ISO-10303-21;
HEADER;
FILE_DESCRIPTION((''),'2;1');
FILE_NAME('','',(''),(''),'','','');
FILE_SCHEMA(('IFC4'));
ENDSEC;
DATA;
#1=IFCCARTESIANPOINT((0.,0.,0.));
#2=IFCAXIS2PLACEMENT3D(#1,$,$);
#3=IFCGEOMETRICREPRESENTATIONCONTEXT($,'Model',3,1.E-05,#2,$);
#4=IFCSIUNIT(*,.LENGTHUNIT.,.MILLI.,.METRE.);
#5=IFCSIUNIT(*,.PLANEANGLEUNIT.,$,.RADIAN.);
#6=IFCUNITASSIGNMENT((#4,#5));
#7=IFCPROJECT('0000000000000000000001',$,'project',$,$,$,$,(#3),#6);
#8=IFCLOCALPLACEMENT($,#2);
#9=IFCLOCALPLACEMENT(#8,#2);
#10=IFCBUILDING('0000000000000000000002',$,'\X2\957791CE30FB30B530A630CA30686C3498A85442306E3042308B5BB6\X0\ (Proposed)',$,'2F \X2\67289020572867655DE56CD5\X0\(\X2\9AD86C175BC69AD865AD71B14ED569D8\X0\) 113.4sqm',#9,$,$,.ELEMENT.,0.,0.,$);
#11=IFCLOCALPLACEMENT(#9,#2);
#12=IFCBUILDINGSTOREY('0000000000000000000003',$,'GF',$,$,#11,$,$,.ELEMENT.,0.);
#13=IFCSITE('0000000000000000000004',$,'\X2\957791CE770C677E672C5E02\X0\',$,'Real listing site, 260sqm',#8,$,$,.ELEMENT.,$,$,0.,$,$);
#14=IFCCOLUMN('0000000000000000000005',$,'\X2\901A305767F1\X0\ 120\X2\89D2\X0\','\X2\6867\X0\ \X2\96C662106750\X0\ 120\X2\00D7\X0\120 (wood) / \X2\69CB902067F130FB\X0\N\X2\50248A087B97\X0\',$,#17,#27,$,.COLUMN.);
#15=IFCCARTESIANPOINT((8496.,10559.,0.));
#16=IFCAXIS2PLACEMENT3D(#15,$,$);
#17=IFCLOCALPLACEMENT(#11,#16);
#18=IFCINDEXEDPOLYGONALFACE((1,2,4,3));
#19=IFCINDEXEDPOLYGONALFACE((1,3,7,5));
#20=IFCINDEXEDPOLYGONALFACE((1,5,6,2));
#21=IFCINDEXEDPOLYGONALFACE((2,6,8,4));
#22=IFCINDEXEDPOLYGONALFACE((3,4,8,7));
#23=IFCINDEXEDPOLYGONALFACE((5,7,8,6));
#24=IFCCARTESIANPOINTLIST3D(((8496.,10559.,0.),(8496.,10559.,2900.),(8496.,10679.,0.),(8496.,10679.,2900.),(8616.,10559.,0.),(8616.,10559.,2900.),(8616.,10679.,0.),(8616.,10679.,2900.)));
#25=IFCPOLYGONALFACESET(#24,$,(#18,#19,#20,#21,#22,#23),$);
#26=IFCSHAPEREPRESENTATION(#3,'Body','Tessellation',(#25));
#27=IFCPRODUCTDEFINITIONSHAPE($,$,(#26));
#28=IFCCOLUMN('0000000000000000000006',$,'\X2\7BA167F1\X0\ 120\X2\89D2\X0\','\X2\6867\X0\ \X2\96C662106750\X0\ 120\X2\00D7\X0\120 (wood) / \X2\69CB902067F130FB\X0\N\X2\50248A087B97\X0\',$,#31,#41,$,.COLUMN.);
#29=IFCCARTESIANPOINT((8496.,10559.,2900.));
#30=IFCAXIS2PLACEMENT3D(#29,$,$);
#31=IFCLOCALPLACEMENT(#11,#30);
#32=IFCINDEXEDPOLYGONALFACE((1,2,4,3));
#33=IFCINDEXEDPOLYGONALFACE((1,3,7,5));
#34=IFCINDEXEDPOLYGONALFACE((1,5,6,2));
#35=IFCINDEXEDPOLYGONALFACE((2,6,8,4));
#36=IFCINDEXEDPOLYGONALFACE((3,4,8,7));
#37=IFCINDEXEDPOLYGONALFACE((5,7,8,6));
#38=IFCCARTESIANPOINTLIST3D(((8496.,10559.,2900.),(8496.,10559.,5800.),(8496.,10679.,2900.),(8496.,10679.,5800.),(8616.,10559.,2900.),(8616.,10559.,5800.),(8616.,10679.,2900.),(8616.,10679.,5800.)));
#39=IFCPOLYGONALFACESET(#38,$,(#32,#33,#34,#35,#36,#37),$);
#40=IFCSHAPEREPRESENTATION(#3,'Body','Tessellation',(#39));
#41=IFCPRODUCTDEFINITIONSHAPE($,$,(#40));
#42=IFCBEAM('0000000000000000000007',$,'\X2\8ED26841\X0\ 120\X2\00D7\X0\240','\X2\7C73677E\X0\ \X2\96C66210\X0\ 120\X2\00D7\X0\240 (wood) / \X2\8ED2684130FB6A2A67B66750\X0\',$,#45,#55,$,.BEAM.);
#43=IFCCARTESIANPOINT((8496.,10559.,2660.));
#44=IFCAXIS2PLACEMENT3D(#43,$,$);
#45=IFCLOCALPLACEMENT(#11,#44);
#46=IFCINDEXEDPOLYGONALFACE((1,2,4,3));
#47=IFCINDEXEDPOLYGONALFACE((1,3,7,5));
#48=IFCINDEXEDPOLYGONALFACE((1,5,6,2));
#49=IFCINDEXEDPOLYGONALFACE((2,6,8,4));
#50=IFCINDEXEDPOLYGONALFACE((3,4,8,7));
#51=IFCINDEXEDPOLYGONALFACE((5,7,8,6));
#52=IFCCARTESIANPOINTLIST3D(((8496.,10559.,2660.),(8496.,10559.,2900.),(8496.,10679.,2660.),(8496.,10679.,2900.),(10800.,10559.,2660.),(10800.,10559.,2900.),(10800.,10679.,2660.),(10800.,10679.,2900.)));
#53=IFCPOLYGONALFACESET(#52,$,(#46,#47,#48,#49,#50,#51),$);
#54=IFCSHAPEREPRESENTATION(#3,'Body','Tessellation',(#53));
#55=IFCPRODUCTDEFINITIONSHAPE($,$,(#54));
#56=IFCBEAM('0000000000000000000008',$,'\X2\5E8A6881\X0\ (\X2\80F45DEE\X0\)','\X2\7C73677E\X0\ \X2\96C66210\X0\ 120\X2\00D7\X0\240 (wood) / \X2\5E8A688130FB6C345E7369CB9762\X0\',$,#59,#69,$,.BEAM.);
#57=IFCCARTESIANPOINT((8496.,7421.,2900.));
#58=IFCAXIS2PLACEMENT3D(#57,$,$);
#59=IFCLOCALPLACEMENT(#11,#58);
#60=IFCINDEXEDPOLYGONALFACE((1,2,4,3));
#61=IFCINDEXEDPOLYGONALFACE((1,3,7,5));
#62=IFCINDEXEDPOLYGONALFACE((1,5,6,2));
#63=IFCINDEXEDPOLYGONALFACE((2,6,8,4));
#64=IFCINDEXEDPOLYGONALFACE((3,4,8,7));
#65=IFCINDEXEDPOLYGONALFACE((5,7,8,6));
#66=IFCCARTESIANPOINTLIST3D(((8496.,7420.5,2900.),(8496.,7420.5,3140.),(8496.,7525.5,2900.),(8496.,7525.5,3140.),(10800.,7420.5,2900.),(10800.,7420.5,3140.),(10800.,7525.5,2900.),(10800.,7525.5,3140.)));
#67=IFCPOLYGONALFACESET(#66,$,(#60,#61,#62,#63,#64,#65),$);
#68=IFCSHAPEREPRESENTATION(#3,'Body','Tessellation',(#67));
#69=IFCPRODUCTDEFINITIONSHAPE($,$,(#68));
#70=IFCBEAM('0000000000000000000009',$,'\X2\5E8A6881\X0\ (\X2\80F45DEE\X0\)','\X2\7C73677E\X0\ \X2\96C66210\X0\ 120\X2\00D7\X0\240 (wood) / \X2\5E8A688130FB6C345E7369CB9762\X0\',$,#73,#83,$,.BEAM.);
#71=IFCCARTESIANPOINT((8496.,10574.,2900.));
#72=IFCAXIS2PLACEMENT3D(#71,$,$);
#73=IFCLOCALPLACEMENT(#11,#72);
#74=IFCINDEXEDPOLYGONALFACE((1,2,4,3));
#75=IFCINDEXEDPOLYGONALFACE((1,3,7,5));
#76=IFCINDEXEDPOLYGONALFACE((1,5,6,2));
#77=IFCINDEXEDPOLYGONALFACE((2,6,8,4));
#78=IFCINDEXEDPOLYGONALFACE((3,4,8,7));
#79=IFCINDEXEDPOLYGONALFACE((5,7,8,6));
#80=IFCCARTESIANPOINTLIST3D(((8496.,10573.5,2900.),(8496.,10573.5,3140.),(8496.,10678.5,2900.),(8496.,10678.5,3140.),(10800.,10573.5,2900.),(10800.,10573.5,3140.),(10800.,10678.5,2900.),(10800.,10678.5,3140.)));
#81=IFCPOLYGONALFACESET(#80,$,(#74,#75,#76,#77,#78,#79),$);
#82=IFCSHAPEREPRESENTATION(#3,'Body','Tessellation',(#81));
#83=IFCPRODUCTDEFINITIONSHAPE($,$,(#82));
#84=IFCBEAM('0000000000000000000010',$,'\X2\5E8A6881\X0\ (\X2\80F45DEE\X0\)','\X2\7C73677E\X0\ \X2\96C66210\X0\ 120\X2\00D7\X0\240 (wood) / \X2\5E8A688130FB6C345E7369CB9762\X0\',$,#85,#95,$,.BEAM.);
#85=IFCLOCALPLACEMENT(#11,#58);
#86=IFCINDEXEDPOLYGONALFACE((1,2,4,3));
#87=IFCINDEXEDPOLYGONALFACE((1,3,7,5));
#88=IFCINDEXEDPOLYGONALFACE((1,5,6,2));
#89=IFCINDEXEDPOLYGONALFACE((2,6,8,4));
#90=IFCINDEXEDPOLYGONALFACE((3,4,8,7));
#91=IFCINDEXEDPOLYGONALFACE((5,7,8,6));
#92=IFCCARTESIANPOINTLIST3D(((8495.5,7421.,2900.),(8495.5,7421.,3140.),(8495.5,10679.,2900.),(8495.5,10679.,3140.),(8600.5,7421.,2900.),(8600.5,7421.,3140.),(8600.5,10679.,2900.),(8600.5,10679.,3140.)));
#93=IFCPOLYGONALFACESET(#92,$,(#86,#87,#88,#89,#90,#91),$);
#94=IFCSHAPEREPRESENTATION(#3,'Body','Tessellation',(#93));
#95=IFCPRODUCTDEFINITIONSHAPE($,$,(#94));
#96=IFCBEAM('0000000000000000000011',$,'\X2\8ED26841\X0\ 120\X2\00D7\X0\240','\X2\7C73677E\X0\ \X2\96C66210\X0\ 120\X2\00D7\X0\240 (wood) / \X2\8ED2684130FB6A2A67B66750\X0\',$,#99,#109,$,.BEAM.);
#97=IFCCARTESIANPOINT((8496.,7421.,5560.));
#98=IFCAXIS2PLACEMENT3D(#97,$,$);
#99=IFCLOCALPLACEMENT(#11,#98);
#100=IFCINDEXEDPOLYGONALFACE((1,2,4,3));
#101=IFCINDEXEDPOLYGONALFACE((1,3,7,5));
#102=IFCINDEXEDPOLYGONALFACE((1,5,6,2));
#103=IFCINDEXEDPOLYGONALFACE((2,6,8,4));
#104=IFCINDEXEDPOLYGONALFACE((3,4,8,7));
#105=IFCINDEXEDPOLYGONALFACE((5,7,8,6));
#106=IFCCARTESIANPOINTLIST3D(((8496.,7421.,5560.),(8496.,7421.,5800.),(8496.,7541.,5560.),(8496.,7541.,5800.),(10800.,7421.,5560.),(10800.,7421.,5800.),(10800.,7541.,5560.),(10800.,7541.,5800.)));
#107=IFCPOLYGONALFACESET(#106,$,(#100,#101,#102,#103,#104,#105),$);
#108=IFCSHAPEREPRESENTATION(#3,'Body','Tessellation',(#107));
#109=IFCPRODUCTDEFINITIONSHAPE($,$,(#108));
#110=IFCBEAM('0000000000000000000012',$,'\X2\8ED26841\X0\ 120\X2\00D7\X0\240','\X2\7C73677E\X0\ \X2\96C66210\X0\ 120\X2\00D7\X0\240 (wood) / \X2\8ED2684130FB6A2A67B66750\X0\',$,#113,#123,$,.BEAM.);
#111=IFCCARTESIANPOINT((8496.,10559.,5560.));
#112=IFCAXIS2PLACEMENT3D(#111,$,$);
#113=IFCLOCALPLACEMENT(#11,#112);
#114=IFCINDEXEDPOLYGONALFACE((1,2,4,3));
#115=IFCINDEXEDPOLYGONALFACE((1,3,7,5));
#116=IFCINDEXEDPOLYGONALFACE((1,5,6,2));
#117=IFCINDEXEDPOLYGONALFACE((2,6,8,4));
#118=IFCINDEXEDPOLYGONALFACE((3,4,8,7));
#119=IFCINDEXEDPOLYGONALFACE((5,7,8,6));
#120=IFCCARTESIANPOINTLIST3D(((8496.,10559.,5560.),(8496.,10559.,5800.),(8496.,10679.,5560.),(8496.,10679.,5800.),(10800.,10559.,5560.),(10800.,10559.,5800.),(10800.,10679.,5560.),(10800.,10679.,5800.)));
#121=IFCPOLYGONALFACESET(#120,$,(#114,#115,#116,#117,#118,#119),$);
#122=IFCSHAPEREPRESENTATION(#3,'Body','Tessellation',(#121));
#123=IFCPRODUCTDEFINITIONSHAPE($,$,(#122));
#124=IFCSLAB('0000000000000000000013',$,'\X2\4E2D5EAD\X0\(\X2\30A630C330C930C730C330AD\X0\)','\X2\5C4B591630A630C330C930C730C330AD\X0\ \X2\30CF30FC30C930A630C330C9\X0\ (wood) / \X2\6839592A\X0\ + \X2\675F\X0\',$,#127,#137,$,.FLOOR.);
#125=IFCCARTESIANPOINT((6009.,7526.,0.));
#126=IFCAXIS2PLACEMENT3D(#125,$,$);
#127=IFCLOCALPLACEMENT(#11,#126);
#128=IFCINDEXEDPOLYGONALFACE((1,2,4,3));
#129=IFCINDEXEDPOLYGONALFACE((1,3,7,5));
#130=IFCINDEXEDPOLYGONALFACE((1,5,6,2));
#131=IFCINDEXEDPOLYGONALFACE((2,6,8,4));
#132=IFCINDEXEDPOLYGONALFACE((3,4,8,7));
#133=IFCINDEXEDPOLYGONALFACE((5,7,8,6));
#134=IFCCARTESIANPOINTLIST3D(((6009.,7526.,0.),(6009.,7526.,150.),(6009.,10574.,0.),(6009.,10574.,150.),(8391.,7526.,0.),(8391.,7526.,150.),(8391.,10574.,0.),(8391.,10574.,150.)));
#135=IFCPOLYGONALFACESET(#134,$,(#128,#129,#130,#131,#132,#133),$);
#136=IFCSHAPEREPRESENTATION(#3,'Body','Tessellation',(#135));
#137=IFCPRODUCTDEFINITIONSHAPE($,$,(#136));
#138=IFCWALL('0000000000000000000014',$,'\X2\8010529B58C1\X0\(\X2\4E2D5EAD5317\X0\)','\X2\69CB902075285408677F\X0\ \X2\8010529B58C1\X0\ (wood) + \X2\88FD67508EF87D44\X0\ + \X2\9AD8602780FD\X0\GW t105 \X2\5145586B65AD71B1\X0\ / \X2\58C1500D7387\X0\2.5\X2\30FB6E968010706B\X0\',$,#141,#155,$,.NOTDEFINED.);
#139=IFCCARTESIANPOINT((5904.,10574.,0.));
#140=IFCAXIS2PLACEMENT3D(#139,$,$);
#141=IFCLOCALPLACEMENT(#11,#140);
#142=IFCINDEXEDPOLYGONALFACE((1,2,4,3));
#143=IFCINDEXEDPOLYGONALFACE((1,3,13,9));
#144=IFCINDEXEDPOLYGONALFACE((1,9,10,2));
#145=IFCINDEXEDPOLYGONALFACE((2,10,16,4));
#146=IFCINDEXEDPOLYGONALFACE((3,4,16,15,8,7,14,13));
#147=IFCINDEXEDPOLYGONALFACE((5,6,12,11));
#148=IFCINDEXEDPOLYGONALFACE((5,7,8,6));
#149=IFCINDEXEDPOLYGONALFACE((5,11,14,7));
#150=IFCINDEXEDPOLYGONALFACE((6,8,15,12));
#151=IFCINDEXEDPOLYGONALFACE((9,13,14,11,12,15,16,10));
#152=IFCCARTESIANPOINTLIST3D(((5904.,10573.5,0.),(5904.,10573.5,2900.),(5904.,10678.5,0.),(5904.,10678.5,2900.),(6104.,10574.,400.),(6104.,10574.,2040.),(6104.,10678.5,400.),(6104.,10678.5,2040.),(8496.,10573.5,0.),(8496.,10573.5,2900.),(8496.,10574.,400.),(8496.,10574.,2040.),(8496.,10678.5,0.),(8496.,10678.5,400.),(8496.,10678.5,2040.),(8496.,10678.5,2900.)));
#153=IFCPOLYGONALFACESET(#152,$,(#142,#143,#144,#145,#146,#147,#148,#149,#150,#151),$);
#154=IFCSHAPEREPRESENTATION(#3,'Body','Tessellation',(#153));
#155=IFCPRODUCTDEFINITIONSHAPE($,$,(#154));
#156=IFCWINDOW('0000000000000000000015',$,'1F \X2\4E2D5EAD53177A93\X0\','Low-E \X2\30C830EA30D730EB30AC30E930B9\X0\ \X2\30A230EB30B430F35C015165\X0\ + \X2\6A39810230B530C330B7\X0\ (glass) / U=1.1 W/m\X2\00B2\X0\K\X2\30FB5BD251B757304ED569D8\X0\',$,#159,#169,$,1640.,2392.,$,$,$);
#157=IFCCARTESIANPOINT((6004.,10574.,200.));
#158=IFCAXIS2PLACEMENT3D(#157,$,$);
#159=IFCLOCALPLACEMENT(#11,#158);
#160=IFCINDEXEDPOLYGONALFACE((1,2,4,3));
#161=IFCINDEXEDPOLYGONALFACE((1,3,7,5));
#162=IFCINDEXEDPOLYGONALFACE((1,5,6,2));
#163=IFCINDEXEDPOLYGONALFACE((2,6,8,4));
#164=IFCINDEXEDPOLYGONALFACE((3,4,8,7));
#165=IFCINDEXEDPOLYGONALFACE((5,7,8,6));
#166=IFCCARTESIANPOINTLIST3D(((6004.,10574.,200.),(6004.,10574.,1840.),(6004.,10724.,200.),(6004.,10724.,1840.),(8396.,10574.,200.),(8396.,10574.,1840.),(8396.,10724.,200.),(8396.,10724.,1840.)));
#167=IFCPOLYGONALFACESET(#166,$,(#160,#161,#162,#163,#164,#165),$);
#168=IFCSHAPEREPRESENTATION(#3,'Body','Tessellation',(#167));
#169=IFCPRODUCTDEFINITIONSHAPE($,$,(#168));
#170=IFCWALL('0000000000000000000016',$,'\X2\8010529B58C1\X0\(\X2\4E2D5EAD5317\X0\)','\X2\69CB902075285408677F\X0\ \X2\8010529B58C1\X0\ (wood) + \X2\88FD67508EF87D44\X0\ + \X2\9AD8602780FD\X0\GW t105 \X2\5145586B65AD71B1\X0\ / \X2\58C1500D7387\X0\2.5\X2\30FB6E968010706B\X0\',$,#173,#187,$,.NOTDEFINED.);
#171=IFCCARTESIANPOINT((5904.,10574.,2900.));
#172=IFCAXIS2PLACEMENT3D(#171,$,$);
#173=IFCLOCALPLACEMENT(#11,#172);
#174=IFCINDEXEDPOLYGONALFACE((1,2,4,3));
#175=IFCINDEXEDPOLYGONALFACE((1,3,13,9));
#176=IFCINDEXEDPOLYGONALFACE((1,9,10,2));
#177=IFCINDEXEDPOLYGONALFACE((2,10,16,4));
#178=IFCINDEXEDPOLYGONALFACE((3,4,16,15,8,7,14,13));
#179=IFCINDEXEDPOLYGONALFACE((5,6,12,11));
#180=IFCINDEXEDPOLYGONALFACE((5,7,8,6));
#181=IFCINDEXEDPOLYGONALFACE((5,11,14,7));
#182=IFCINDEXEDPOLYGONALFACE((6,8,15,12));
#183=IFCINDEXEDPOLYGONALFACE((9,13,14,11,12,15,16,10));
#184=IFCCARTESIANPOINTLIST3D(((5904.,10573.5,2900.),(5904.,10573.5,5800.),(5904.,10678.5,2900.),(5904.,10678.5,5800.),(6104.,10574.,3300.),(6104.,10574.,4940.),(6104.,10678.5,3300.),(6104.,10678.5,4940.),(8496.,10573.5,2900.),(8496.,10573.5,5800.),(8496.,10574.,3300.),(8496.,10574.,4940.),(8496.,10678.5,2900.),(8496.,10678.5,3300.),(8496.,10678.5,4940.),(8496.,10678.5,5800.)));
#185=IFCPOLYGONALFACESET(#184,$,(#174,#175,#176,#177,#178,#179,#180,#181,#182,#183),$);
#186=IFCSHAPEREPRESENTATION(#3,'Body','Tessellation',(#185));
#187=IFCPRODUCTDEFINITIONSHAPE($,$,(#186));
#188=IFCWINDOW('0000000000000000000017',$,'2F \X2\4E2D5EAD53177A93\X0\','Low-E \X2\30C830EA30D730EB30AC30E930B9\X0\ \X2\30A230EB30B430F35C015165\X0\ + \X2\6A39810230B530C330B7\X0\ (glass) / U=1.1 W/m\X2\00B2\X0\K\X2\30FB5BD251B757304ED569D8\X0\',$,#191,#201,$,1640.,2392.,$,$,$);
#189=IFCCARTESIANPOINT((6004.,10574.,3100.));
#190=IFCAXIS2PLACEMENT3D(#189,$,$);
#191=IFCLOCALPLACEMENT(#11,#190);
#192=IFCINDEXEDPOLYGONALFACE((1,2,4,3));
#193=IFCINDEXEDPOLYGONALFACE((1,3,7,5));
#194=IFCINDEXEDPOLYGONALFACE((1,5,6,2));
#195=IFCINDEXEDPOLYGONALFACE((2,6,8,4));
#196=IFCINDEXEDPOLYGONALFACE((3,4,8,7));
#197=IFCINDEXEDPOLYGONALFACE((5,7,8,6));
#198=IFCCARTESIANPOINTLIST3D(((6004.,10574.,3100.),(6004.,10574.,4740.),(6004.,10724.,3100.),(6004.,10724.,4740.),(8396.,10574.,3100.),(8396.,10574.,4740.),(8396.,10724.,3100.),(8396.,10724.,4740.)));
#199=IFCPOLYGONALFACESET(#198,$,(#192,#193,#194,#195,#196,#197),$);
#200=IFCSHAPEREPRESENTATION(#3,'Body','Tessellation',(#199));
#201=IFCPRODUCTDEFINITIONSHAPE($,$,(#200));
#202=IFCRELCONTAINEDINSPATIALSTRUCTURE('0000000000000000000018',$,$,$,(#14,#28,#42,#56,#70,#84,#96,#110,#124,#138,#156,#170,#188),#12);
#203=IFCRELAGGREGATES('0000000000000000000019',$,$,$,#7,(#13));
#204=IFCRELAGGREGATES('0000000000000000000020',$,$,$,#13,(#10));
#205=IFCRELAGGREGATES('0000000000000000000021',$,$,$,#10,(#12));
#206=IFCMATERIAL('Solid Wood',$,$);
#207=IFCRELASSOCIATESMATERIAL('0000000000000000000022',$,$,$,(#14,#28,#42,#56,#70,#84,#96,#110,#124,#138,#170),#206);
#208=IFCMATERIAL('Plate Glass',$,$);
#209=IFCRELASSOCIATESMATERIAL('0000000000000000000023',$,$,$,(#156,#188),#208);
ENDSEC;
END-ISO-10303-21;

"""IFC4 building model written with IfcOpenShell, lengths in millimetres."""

from ifc_helpers import new_model, si_unit, frame, frame_2d, origin, place, context, project, spatial, rectangle, extrude, material, element, fill, save


model = new_model("IFC4")

# Units and contexts
model_context = context("Model", 3, precision=1e-05, world=origin())
ifc_project = project(units=[si_unit("LENGTHUNIT", "METRE", prefix="MILLI"), si_unit("PLANEANGLEUNIT", "RADIAN")], contexts=[model_context])

# Site, building, storey
site_placement = place(None, origin())
site = spatial("IfcSite", under=ifc_project, at=site_placement, Name="長野県松本市", ObjectType="Real listing site, 260sqm", CompositionType="ELEMENT", RefElevation=0.0)
building_placement = place(site_placement, origin())
building = spatial("IfcBuilding", under=site, at=building_placement, Name="長野・サウナと水風呂のある家 (Proposed)", ObjectType="2F 木造在来工法(高気密高断熱仕様) 113.4sqm", CompositionType="ELEMENT", ElevationOfRefHeight=0.0, ElevationOfTerrain=0.0)
storey_placement = place(building_placement, origin())
storey = spatial("IfcBuildingStorey", under=building, at=storey_placement, Name="GF", CompositionType="ELEMENT", Elevation=0.0)

# Columns
ifc_material_1 = material(Name="Solid Wood")
column_1_placement = place(storey_placement, frame((8496.0, 10559.0, 0.0)))
element("IfcColumn", 1, at=column_1_placement, inside=storey, material=ifc_material_1, Name="通し柱 120角", Description="桧 集成材 120×120 (wood) / 構造柱・N値計算", PredefinedType="COLUMN", context=model_context, shape_type="SweptSolid", body=[
    extrude(rectangle(XDim=120.0, YDim=120.0, at=frame_2d((60.0, 60.0))), frame((8496.0, 10559.0, 0.0)), (0.0, 0.0, 1.0), 2900.0),
])
column_2_placement = place(storey_placement, frame((8496.0, 10559.0, 2900.0)))
element("IfcColumn", 2, at=column_2_placement, inside=storey, material=ifc_material_1, Name="管柱 120角", Description="桧 集成材 120×120 (wood) / 構造柱・N値計算", PredefinedType="COLUMN", context=model_context, shape_type="SweptSolid", body=[
    extrude(rectangle(XDim=120.0, YDim=120.0, at=frame_2d((60.0, 60.0))), frame((8496.0, 10559.0, 2900.0)), (0.0, 0.0, 1.0), 2900.0),
])

# Beams
beam_1_placement = place(storey_placement, frame((8496.0, 10559.0, 2660.0)))
element("IfcBeam", 3, at=beam_1_placement, inside=storey, material=ifc_material_1, Name="軒桁 120×240", Description="米松 集成 120×240 (wood) / 軒桁・横架材", PredefinedType="BEAM", context=model_context, shape_type="SweptSolid", body=[
    extrude(rectangle(XDim=2304.0, YDim=120.0, at=frame_2d((1152.0, 60.0))), frame((8496.0, 10559.0, 2660.0)), (0.0, 0.0, 1.0), 240.0),
])
beam_2_placement = place(storey_placement, frame((8496.0, 7421.0, 2900.0)))
element("IfcBeam", 4, at=beam_2_placement, inside=storey, material=ifc_material_1, Name="床梁 (胴差)", Description="米松 集成 120×240 (wood) / 床梁・水平構面", PredefinedType="BEAM", context=model_context, shape_type="SweptSolid", body=[
    extrude(rectangle(XDim=2304.0, YDim=105.0, at=frame_2d((1152.0, 52.0))), frame((8496.0, 7421.0, 2900.0)), (0.0, 0.0, 1.0), 240.0),
])
beam_3_placement = place(storey_placement, frame((8496.0, 10574.0, 2900.0)))
element("IfcBeam", 5, at=beam_3_placement, inside=storey, material=ifc_material_1, Name="床梁 (胴差)", Description="米松 集成 120×240 (wood) / 床梁・水平構面", PredefinedType="BEAM", context=model_context, shape_type="SweptSolid", body=[
    extrude(rectangle(XDim=2304.0, YDim=105.0, at=frame_2d((1152.0, 52.0))), frame((8496.0, 10574.0, 2900.0)), (0.0, 0.0, 1.0), 240.0),
])
beam_4_placement = place(storey_placement, frame((8496.0, 7421.0, 2900.0)))
element("IfcBeam", 6, at=beam_4_placement, inside=storey, material=ifc_material_1, Name="床梁 (胴差)", Description="米松 集成 120×240 (wood) / 床梁・水平構面", PredefinedType="BEAM", context=model_context, shape_type="SweptSolid", body=[
    extrude(rectangle(XDim=105.0, YDim=3258.0, at=frame_2d((52.0, 1629.0))), frame((8496.0, 7421.0, 2900.0)), (0.0, 0.0, 1.0), 240.0),
])
beam_5_placement = place(storey_placement, frame((8496.0, 7421.0, 5560.0)))
element("IfcBeam", 7, at=beam_5_placement, inside=storey, material=ifc_material_1, Name="軒桁 120×240", Description="米松 集成 120×240 (wood) / 軒桁・横架材", PredefinedType="BEAM", context=model_context, shape_type="SweptSolid", body=[
    extrude(rectangle(XDim=2304.0, YDim=120.0, at=frame_2d((1152.0, 60.0))), frame((8496.0, 7421.0, 5560.0)), (0.0, 0.0, 1.0), 240.0),
])
beam_6_placement = place(storey_placement, frame((8496.0, 10559.0, 5560.0)))
element("IfcBeam", 8, at=beam_6_placement, inside=storey, material=ifc_material_1, Name="軒桁 120×240", Description="米松 集成 120×240 (wood) / 軒桁・横架材", PredefinedType="BEAM", context=model_context, shape_type="SweptSolid", body=[
    extrude(rectangle(XDim=2304.0, YDim=120.0, at=frame_2d((1152.0, 60.0))), frame((8496.0, 10559.0, 5560.0)), (0.0, 0.0, 1.0), 240.0),
])

# Slab
slab_placement = place(storey_placement, frame((6009.0, 7526.0, 0.0)))
element("IfcSlab", 9, at=slab_placement, inside=storey, material=ifc_material_1, Name="中庭(ウッドデッキ)", Description="屋外ウッドデッキ ハードウッド (wood) / 根太 + 束", PredefinedType="FLOOR", context=model_context, shape_type="SweptSolid", body=[
    extrude(rectangle(XDim=2382.0, YDim=3048.0, at=frame_2d((1191.0, 1524.0))), frame((6009.0, 7526.0, 0.0)), (0.0, 0.0, 1.0), 150.0),
])

# Wall, opening, window
wall_1_placement = place(storey_placement, frame((5904.0, 10574.0, 0.0)))
wall_1 = element("IfcWall", 10, at=wall_1_placement, inside=storey, material=ifc_material_1, Name="耐力壁(中庭北)", Description="構造用合板 耐力壁 (wood) + 製材軸組 + 高性能GW t105 充填断熱 / 壁倍率2.5・準耐火", PredefinedType="NOTDEFINED", context=model_context, shape_type="SweptSolid", body=[
    extrude(rectangle(XDim=2592.0, YDim=105.0, at=frame_2d((1296.0, 52.0))), frame((5904.0, 10574.0, 0.0)), (0.0, 0.0, 1.0), 2900.0),
])
opening_1_placement = place(storey_placement, frame((6004.0, 10574.0, 200.0)))
opening_1 = element("IfcOpeningElement", 11, at=opening_1_placement, cuts=wall_1, PredefinedType="NOTDEFINED", context=model_context, shape_type="SweptSolid", body=[
    extrude(rectangle(XDim=2392.0, YDim=150.0, at=frame_2d((1196.0, 75.0))), frame((6004.0, 10574.0, 200.0)), (0.0, 0.0, 1.0), 1640.0),
])
ifc_material_2 = material(Name="Plate Glass")
window_1_placement = place(storey_placement, frame((6004.0, 10574.0, 200.0)))
window_1 = element("IfcWindow", 12, at=window_1_placement, inside=storey, material=ifc_material_2, Name="1F 中庭北窓", Description="Low-E トリプルガラス アルゴン封入 + 樹脂サッシ (glass) / U=1.1 W/m²K・寒冷地仕様", OverallHeight=1640.0, OverallWidth=2392.0, context=model_context, shape_type="SweptSolid", body=[
    extrude(rectangle(XDim=2392.0, YDim=150.0, at=frame_2d((1196.0, 75.0))), frame((6004.0, 10574.0, 200.0)), (0.0, 0.0, 1.0), 1640.0),
])
fill(opening_1, window_1)

# Wall, opening, window
wall_2_placement = place(storey_placement, frame((5904.0, 10574.0, 2900.0)))
wall_2 = element("IfcWall", 13, at=wall_2_placement, inside=storey, material=ifc_material_1, Name="耐力壁(中庭北)", Description="構造用合板 耐力壁 (wood) + 製材軸組 + 高性能GW t105 充填断熱 / 壁倍率2.5・準耐火", PredefinedType="NOTDEFINED", context=model_context, shape_type="SweptSolid", body=[
    extrude(rectangle(XDim=2592.0, YDim=105.0, at=frame_2d((1296.0, 52.0))), frame((5904.0, 10574.0, 2900.0)), (0.0, 0.0, 1.0), 2900.0),
])
opening_2_placement = place(storey_placement, frame((6004.0, 10574.0, 3100.0)))
opening_2 = element("IfcOpeningElement", 14, at=opening_2_placement, cuts=wall_2, PredefinedType="NOTDEFINED", context=model_context, shape_type="SweptSolid", body=[
    extrude(rectangle(XDim=2392.0, YDim=150.0, at=frame_2d((1196.0, 75.0))), frame((6004.0, 10574.0, 3100.0)), (0.0, 0.0, 1.0), 1640.0),
])
window_2_placement = place(storey_placement, frame((6004.0, 10574.0, 3100.0)))
window_2 = element("IfcWindow", 15, at=window_2_placement, inside=storey, material=ifc_material_2, Name="2F 中庭北窓", Description="Low-E トリプルガラス アルゴン封入 + 樹脂サッシ (glass) / U=1.1 W/m²K・寒冷地仕様", OverallHeight=1640.0, OverallWidth=2392.0, context=model_context, shape_type="SweptSolid", body=[
    extrude(rectangle(XDim=2392.0, YDim=150.0, at=frame_2d((1196.0, 75.0))), frame((6004.0, 10574.0, 3100.0)), (0.0, 0.0, 1.0), 1640.0),
])
fill(opening_2, window_2)

save(model, "model.ifc")
